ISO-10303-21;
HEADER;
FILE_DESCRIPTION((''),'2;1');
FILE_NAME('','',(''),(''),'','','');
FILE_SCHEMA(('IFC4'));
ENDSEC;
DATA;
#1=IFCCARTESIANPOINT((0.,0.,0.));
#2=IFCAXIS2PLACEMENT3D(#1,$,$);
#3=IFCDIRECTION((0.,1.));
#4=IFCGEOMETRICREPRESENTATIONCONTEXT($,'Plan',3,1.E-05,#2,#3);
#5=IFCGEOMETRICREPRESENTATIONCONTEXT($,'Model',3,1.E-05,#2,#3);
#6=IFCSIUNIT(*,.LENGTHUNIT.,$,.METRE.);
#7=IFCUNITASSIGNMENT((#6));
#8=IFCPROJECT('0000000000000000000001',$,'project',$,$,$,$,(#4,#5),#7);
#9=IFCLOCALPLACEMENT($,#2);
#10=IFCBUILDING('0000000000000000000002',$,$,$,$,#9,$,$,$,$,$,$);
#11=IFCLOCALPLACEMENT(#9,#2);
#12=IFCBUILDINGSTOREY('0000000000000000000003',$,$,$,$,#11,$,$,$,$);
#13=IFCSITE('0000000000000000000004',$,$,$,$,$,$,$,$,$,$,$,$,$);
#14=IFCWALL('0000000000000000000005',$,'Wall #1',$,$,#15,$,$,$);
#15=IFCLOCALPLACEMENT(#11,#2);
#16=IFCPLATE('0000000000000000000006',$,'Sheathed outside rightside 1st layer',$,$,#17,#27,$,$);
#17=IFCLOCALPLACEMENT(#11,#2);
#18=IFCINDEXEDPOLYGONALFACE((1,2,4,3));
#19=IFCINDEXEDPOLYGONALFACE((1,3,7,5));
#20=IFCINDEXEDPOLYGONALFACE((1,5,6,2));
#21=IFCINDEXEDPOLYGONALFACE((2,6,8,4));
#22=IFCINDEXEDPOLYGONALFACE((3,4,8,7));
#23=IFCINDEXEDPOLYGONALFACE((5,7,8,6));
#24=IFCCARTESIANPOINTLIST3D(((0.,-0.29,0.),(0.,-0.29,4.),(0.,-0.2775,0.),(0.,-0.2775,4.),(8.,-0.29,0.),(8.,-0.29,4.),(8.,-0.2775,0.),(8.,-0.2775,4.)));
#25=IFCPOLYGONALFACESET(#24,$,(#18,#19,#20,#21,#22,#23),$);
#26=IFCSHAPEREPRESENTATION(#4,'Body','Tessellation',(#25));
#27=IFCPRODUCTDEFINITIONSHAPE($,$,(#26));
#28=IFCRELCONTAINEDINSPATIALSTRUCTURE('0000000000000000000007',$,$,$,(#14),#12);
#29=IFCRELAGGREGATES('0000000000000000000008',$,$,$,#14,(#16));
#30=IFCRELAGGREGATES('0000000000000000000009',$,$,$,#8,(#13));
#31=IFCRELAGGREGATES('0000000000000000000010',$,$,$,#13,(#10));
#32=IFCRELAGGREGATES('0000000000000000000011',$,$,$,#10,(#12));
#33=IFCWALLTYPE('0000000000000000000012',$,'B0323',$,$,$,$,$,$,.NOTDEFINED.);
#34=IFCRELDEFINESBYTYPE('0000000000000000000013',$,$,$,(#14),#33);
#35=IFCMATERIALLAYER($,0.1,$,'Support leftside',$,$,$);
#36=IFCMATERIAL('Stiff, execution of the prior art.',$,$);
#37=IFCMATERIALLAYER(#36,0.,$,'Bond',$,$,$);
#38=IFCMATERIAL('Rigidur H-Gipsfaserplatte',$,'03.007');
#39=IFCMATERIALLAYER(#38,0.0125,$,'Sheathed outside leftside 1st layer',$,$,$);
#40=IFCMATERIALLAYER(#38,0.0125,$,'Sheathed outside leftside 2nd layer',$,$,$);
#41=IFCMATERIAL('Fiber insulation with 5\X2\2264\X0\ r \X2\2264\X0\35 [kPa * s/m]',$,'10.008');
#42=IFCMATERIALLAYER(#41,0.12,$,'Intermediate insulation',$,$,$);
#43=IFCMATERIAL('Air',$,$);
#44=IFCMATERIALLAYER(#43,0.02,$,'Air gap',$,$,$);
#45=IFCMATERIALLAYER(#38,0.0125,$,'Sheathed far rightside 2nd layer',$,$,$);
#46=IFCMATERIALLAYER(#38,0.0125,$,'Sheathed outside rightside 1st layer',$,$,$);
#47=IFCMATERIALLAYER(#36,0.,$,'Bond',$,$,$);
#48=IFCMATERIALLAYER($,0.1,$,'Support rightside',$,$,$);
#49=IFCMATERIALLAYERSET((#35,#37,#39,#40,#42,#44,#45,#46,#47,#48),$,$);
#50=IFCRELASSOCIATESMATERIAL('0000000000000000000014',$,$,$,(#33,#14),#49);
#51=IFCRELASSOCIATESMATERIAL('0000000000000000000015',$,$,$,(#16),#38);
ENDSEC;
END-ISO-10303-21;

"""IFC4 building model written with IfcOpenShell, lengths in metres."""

from ifc_helpers import new_model, si_unit, direction, frame, frame_2d, origin, place, context, project, spatial, rectangle, extrude, material, layer, layer_set, type_object, element, aggregate, save


model = new_model("IFC4")

# Units and contexts
plan_context = context("Plan", 3, precision=1e-05, world=origin(), true_north=direction((0.0, 1.0)))
model_context = context("Model", 3, precision=1e-05, world=origin(), true_north=direction((0.0, 1.0)))
ifc_project = project(units=[si_unit("LENGTHUNIT", "METRE")], contexts=[plan_context, model_context])

# Site, building, storey
site = spatial("IfcSite", under=ifc_project)
building_placement = place(None, origin())
building = spatial("IfcBuilding", under=site, at=building_placement)
storey_placement = place(building_placement, origin())
storey = spatial("IfcBuildingStorey", under=building, at=storey_placement)

# Wall, plate
ifc_layer_1 = layer(None, 0.1, Name="Support leftside")
ifc_material_1 = material(Name="Stiff, execution of the prior art.")
ifc_layer_2 = layer(ifc_material_1, 0.0, Name="Bond")
ifc_material_2 = material(Name="Rigidur H-Gipsfaserplatte", Category="03.007")
ifc_layer_3 = layer(ifc_material_2, 0.0125, Name="Sheathed outside leftside 1st layer")
ifc_layer_4 = layer(ifc_material_2, 0.0125, Name="Sheathed outside leftside 2nd layer")
ifc_material_3 = material(Name="Fiber insulation with 5≤ r ≤35 [kPa * s/m]", Category="10.008")
ifc_layer_5 = layer(ifc_material_3, 0.12, Name="Intermediate insulation")
ifc_material_4 = material(Name="Air")
ifc_layer_6 = layer(ifc_material_4, 0.02, Name="Air gap")
ifc_layer_7 = layer(ifc_material_2, 0.0125, Name="Sheathed far rightside 2nd layer")
ifc_layer_8 = layer(ifc_material_2, 0.0125, Name="Sheathed outside rightside 1st layer")
ifc_layer_9 = layer(ifc_material_1, 0.0, Name="Bond")
ifc_layer_10 = layer(None, 0.1, Name="Support rightside")
ifc_layer_set = layer_set([ifc_layer_1, ifc_layer_2, ifc_layer_3, ifc_layer_4, ifc_layer_5, ifc_layer_6, ifc_layer_7, ifc_layer_8, ifc_layer_9, ifc_layer_10])
wall_type = type_object("IfcWallType", Name="B0323", PredefinedType="NOTDEFINED", material=ifc_layer_set)
wall_placement = place(None, frame((0.0, 0.0, 0.0), z_axis=(0.0, -1.0, 0.0), x_axis=(1.0, 0.0, 0.0)))
wall = element("IfcWall", 1, at=wall_placement, inside=storey, type_object=wall_type, material=ifc_layer_set, Name="Wall #1")
plate_1_placement = place(wall_placement, origin())
plate_1 = element("IfcPlate", 2, at=plate_1_placement, material=ifc_material_2, Name="Sheathed outside rightside 1st layer", context=plan_context, shape_type="SweptSolid", body=[
    extrude(rectangle(XDim=8.0, YDim=4.0, at=frame_2d((4.0, 2.0), x_axis=(1.0, 0.0))), frame((0.0, 0.0, 0.2775), z_axis=(0.0, 0.0, 1.0), x_axis=(1.0, 0.0, 0.0)), (0.0, 0.0, 1.0), 0.0125),
])
aggregate(wall, [plate_1])

save(model, "model.ifc")
